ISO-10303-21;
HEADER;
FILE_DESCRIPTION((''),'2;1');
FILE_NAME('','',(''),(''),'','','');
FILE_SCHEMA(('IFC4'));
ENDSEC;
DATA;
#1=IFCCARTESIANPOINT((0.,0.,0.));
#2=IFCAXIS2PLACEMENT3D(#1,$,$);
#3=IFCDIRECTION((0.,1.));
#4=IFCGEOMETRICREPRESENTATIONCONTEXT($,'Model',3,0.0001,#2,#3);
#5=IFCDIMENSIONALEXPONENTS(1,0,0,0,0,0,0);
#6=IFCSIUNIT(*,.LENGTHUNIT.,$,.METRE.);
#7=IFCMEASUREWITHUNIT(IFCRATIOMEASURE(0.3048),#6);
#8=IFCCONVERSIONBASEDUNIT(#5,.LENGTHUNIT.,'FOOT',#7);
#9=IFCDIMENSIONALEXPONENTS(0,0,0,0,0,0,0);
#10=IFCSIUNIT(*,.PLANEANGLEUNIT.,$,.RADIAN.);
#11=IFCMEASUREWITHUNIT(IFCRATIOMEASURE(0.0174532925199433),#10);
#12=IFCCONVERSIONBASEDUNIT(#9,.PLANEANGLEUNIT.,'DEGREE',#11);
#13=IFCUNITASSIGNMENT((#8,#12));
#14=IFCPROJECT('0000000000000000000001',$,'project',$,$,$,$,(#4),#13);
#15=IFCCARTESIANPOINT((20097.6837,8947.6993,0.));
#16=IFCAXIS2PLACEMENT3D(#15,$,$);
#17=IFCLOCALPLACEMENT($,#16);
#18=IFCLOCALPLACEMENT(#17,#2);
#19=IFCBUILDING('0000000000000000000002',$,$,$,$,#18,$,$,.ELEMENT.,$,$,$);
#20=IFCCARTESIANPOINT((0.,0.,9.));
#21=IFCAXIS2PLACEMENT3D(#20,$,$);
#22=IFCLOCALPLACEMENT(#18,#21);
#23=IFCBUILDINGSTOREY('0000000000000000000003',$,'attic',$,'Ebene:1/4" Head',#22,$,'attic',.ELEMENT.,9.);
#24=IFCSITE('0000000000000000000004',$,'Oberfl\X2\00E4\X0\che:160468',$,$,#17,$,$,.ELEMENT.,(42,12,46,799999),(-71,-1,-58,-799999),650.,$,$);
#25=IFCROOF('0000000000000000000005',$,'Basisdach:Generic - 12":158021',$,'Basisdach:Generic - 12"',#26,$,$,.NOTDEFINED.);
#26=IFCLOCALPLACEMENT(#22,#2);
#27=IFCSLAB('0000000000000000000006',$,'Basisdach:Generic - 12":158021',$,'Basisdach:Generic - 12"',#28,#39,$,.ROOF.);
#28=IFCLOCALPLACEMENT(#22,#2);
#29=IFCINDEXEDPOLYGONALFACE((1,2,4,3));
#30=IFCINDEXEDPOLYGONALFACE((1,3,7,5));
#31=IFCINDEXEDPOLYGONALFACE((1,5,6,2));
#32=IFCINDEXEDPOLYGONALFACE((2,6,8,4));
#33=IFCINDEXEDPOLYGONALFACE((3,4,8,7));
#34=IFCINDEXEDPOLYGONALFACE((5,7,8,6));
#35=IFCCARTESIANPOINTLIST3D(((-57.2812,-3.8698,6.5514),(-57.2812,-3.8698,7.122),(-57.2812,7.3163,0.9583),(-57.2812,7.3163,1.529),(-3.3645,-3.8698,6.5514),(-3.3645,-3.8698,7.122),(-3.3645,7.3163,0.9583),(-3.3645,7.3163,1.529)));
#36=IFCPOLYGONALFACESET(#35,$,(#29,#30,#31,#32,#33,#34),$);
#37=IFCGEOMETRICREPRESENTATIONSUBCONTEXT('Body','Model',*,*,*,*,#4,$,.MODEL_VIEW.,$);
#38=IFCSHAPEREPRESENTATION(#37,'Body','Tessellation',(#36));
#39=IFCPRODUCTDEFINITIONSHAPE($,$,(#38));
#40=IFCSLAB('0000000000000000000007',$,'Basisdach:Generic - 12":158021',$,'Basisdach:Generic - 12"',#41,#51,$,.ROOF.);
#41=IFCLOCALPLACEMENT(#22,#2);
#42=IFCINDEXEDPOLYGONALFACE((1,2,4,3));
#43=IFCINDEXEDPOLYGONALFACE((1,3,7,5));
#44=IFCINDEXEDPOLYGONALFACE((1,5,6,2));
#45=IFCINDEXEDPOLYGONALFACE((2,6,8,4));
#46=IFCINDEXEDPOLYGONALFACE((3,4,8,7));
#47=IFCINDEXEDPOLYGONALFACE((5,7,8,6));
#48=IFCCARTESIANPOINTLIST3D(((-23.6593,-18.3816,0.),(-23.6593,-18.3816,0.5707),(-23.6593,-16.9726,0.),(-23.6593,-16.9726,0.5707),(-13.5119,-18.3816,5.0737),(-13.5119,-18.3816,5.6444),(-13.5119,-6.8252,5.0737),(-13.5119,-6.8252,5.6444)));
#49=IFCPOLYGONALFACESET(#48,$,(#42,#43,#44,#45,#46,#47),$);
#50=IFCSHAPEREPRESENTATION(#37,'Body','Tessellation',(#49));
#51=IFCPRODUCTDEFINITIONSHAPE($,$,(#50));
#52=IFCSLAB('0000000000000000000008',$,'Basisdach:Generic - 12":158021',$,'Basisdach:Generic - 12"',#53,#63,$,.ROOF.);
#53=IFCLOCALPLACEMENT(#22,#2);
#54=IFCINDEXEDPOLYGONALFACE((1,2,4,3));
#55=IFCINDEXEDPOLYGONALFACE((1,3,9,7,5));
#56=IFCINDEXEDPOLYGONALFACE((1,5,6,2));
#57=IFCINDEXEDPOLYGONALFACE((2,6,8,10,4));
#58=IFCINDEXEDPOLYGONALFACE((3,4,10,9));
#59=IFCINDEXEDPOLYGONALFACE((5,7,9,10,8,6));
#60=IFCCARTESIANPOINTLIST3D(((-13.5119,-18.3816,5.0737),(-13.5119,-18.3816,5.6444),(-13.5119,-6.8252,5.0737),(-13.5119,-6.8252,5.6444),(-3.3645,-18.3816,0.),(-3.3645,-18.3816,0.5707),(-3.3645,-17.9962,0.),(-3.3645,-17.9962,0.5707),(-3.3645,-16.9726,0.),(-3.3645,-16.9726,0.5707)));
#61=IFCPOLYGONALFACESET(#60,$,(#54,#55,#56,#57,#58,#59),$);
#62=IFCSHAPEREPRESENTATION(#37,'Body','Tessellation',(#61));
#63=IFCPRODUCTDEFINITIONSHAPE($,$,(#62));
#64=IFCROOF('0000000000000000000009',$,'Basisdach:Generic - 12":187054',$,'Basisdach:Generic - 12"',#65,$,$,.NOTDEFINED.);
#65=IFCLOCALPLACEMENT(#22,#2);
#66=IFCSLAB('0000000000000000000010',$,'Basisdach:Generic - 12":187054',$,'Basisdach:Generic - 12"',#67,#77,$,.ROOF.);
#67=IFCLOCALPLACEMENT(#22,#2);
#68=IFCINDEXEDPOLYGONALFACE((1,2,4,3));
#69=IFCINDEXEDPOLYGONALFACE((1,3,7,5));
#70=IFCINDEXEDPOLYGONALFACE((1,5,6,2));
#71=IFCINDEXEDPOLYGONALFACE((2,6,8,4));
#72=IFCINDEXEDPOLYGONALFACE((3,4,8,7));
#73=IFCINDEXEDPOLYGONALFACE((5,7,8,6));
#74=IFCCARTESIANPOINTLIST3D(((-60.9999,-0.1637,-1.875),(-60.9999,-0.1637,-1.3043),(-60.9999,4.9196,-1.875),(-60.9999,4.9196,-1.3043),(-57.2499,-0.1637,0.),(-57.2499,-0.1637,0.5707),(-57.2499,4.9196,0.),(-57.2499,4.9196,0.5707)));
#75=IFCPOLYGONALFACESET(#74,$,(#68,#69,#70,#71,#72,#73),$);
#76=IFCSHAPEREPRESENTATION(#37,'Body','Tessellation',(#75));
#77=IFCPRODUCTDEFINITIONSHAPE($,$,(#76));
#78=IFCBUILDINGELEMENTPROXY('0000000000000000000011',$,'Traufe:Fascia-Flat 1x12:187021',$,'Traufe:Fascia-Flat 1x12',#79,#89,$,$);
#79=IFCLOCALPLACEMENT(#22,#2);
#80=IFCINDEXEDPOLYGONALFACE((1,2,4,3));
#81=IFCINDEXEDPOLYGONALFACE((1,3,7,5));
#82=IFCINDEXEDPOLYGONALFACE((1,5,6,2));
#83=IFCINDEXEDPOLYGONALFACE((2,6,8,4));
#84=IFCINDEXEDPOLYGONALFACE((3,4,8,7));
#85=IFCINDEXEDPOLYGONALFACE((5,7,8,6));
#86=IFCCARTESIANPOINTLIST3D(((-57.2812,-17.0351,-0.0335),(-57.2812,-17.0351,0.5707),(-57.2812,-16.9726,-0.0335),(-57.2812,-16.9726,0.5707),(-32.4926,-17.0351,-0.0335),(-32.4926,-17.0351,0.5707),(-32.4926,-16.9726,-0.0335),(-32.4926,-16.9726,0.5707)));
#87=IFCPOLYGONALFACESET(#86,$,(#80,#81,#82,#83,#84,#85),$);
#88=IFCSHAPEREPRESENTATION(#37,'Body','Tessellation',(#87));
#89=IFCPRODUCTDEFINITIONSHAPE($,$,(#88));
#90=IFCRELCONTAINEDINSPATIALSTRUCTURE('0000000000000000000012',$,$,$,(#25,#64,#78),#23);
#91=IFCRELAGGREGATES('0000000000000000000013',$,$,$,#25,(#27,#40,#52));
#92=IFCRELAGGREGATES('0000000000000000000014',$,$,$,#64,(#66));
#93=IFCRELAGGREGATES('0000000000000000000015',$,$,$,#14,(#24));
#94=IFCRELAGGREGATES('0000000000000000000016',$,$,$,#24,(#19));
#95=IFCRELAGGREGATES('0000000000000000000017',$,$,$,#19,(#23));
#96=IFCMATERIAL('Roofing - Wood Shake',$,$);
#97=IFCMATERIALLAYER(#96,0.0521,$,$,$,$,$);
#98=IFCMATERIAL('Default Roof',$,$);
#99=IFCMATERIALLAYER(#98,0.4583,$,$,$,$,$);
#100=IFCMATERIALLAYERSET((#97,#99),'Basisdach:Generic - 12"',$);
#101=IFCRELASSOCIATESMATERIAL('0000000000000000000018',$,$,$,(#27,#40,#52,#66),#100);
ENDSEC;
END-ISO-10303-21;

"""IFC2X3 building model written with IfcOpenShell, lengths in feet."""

from ifc_helpers import new_model, entity, si_unit, converted_unit, direction, frame, frame_2d, origin, origin_2d_with_axis, place, context, subcontext, project, spatial, polyline, rectangle, outline, extrude, material, layer, layer_set, element, aggregate, save


model = new_model("IFC2X3")

# Units and contexts
model_context = context("Model", 3, precision=0.0001, world=origin(), true_north=direction((0.0, 1.0)))
body_context = subcontext(model_context, "Body", "Model", "MODEL_VIEW")
ifc_project = project(units=[converted_unit("LENGTHUNIT", "FOOT", entity("IfcRatioMeasure", 0.3048), si_unit("LENGTHUNIT", "METRE"), dimensions=[1, 0, 0, 0, 0, 0, 0]), converted_unit("PLANEANGLEUNIT", "DEGREE", entity("IfcRatioMeasure", 0.0174532925199433), si_unit("PLANEANGLEUNIT", "RADIAN"), dimensions=[0, 0, 0, 0, 0, 0, 0])], contexts=[model_context])

# Site, building, storey
site_placement = place(None, frame((20097.6837, 8947.6993, 0.0)))
site = spatial("IfcSite", under=ifc_project, at=site_placement, Name="Oberfläche:160468", CompositionType="ELEMENT", RefLatitude=(42, 12, 46, 799999), RefLongitude=(-71, -1, -58, -799999), RefElevation=650.0)
building_placement = place(site_placement, origin())
building = spatial("IfcBuilding", under=site, at=building_placement, CompositionType="ELEMENT")
storey_placement = place(building_placement, frame((0.0, 0.0, 9.0)))
storey = spatial("IfcBuildingStorey", under=building, at=storey_placement, Name="attic", ObjectType="Ebene:1/4\" Head", LongName="attic", CompositionType="ELEMENT", Elevation=9.0)

# Roof, slabs
roof_1_placement = place(storey_placement, frame((-57.2812, -18.3816, 0.0)))
roof_1 = element("IfcRoof", 1, at=roof_1_placement, inside=storey, Name="Basisdach:Generic - 12\":158021", ObjectType="Basisdach:Generic - 12\"", ShapeType="NOTDEFINED")
ifc_material_1 = material(Name="Roofing - Wood Shake")
ifc_layer_1 = layer(ifc_material_1, 0.0521)
ifc_material_2 = material(Name="Default Roof")
ifc_layer_2 = layer(ifc_material_2, 0.4583)
ifc_layer_set_1 = layer_set([ifc_layer_1, ifc_layer_2], Name="Basisdach:Generic - 12\"")
slab_1_placement = place(roof_1_placement, origin())
slab_1 = element("IfcSlab", 2, at=slab_1_placement, material=ifc_layer_set_1, Name="Basisdach:Generic - 12\":158021", ObjectType="Basisdach:Generic - 12\"", PredefinedType="ROOF", context=body_context, shape_type="SweptSolid", body=[
    extrude(rectangle(XDim=53.9167, YDim=12.5064, at=frame_2d((0.0, 0.0), x_axis=(1.0, 0.0))), frame((26.9583, 20.1049, 3.7549), z_axis=(0.0, 0.447214, 0.894427), x_axis=(1.0, 0.0, 0.0)), (0.0, -0.447214, 0.894427), 0.5707),
])
slab_2_placement = place(roof_1_placement, origin())
slab_2 = element("IfcSlab", 3, at=slab_2_placement, material=ifc_layer_set_1, Name="Basisdach:Generic - 12\":158021", ObjectType="Basisdach:Generic - 12\"", PredefinedType="ROOF", context=body_context, shape_type="SweptSolid", body=[
    extrude(outline(polyline([(-5.6726, -5.7782), (5.6726, -5.7782), (5.6726, 5.7782), (-5.6726, -4.3692), (-5.6726, -5.7782)])), frame((38.6956, 5.7782, 2.5368), z_axis=(-0.447214, 0.0, 0.894427), x_axis=(0.894427, 0.0, 0.447214)), (0.447214, 0.0, 0.894427), 0.5707),
])
slab_3_placement = place(roof_1_placement, origin())
slab_3 = element("IfcSlab", 4, at=slab_3_placement, material=ifc_layer_set_1, Name="Basisdach:Generic - 12\":158021", ObjectType="Basisdach:Generic - 12\"", PredefinedType="ROOF", context=body_context, shape_type="SweptSolid", body=[
    extrude(outline(polyline([(5.6726, -5.3928), (5.6726, -4.3692), (-5.6726, 5.7782), (-5.6726, -5.7782), (5.6726, -5.7782), (5.6726, -5.3928)])), frame((48.843, 5.7782, 2.5368), z_axis=(0.447214, 0.0, 0.894427), x_axis=(0.894427, 0.0, -0.447214)), (-0.447214, 0.0, 0.894427), 0.5707),
])
aggregate(roof_1, [slab_1, slab_2, slab_3])

# Roof, slab
roof_2_placement = place(storey_placement, frame((-60.9999, -0.1637, -1.875)))
roof_2 = element("IfcRoof", 5, at=roof_2_placement, inside=storey, Name="Basisdach:Generic - 12\":187054", ObjectType="Basisdach:Generic - 12\"", ShapeType="NOTDEFINED")
slab_4_placement = place(roof_2_placement, origin())
slab_4 = element("IfcSlab", 6, at=slab_4_placement, material=ifc_layer_set_1, Name="Basisdach:Generic - 12\":187054", ObjectType="Basisdach:Generic - 12\"", PredefinedType="ROOF", context=body_context, shape_type="SweptSolid", body=[
    extrude(rectangle(XDim=4.1926, YDim=5.0833, at=origin_2d_with_axis()), frame((1.875, 2.5417, 0.9375), z_axis=(-0.447214, 0.0, 0.894427), x_axis=(0.894427, 0.0, 0.447214)), (0.447214, 0.0, 0.894427), 0.5707),
])
aggregate(roof_2, [slab_4])

# Building element proxy
proxy_1_placement = place(storey_placement, origin())
element("IfcBuildingElementProxy", 7, at=proxy_1_placement, inside=storey, Name="Traufe:Fascia-Flat 1x12:187021", ObjectType="Traufe:Fascia-Flat 1x12", context=body_context, shape_type="SweptSolid", body=[
    extrude(rectangle(XDim=24.7886, YDim=0.0625, at=origin_2d_with_axis()), frame((-44.8869, -17.0038, -0.0335)), (0.0, 0.0, 1.0), 0.6042),
])

save(model, "model.ifc")
